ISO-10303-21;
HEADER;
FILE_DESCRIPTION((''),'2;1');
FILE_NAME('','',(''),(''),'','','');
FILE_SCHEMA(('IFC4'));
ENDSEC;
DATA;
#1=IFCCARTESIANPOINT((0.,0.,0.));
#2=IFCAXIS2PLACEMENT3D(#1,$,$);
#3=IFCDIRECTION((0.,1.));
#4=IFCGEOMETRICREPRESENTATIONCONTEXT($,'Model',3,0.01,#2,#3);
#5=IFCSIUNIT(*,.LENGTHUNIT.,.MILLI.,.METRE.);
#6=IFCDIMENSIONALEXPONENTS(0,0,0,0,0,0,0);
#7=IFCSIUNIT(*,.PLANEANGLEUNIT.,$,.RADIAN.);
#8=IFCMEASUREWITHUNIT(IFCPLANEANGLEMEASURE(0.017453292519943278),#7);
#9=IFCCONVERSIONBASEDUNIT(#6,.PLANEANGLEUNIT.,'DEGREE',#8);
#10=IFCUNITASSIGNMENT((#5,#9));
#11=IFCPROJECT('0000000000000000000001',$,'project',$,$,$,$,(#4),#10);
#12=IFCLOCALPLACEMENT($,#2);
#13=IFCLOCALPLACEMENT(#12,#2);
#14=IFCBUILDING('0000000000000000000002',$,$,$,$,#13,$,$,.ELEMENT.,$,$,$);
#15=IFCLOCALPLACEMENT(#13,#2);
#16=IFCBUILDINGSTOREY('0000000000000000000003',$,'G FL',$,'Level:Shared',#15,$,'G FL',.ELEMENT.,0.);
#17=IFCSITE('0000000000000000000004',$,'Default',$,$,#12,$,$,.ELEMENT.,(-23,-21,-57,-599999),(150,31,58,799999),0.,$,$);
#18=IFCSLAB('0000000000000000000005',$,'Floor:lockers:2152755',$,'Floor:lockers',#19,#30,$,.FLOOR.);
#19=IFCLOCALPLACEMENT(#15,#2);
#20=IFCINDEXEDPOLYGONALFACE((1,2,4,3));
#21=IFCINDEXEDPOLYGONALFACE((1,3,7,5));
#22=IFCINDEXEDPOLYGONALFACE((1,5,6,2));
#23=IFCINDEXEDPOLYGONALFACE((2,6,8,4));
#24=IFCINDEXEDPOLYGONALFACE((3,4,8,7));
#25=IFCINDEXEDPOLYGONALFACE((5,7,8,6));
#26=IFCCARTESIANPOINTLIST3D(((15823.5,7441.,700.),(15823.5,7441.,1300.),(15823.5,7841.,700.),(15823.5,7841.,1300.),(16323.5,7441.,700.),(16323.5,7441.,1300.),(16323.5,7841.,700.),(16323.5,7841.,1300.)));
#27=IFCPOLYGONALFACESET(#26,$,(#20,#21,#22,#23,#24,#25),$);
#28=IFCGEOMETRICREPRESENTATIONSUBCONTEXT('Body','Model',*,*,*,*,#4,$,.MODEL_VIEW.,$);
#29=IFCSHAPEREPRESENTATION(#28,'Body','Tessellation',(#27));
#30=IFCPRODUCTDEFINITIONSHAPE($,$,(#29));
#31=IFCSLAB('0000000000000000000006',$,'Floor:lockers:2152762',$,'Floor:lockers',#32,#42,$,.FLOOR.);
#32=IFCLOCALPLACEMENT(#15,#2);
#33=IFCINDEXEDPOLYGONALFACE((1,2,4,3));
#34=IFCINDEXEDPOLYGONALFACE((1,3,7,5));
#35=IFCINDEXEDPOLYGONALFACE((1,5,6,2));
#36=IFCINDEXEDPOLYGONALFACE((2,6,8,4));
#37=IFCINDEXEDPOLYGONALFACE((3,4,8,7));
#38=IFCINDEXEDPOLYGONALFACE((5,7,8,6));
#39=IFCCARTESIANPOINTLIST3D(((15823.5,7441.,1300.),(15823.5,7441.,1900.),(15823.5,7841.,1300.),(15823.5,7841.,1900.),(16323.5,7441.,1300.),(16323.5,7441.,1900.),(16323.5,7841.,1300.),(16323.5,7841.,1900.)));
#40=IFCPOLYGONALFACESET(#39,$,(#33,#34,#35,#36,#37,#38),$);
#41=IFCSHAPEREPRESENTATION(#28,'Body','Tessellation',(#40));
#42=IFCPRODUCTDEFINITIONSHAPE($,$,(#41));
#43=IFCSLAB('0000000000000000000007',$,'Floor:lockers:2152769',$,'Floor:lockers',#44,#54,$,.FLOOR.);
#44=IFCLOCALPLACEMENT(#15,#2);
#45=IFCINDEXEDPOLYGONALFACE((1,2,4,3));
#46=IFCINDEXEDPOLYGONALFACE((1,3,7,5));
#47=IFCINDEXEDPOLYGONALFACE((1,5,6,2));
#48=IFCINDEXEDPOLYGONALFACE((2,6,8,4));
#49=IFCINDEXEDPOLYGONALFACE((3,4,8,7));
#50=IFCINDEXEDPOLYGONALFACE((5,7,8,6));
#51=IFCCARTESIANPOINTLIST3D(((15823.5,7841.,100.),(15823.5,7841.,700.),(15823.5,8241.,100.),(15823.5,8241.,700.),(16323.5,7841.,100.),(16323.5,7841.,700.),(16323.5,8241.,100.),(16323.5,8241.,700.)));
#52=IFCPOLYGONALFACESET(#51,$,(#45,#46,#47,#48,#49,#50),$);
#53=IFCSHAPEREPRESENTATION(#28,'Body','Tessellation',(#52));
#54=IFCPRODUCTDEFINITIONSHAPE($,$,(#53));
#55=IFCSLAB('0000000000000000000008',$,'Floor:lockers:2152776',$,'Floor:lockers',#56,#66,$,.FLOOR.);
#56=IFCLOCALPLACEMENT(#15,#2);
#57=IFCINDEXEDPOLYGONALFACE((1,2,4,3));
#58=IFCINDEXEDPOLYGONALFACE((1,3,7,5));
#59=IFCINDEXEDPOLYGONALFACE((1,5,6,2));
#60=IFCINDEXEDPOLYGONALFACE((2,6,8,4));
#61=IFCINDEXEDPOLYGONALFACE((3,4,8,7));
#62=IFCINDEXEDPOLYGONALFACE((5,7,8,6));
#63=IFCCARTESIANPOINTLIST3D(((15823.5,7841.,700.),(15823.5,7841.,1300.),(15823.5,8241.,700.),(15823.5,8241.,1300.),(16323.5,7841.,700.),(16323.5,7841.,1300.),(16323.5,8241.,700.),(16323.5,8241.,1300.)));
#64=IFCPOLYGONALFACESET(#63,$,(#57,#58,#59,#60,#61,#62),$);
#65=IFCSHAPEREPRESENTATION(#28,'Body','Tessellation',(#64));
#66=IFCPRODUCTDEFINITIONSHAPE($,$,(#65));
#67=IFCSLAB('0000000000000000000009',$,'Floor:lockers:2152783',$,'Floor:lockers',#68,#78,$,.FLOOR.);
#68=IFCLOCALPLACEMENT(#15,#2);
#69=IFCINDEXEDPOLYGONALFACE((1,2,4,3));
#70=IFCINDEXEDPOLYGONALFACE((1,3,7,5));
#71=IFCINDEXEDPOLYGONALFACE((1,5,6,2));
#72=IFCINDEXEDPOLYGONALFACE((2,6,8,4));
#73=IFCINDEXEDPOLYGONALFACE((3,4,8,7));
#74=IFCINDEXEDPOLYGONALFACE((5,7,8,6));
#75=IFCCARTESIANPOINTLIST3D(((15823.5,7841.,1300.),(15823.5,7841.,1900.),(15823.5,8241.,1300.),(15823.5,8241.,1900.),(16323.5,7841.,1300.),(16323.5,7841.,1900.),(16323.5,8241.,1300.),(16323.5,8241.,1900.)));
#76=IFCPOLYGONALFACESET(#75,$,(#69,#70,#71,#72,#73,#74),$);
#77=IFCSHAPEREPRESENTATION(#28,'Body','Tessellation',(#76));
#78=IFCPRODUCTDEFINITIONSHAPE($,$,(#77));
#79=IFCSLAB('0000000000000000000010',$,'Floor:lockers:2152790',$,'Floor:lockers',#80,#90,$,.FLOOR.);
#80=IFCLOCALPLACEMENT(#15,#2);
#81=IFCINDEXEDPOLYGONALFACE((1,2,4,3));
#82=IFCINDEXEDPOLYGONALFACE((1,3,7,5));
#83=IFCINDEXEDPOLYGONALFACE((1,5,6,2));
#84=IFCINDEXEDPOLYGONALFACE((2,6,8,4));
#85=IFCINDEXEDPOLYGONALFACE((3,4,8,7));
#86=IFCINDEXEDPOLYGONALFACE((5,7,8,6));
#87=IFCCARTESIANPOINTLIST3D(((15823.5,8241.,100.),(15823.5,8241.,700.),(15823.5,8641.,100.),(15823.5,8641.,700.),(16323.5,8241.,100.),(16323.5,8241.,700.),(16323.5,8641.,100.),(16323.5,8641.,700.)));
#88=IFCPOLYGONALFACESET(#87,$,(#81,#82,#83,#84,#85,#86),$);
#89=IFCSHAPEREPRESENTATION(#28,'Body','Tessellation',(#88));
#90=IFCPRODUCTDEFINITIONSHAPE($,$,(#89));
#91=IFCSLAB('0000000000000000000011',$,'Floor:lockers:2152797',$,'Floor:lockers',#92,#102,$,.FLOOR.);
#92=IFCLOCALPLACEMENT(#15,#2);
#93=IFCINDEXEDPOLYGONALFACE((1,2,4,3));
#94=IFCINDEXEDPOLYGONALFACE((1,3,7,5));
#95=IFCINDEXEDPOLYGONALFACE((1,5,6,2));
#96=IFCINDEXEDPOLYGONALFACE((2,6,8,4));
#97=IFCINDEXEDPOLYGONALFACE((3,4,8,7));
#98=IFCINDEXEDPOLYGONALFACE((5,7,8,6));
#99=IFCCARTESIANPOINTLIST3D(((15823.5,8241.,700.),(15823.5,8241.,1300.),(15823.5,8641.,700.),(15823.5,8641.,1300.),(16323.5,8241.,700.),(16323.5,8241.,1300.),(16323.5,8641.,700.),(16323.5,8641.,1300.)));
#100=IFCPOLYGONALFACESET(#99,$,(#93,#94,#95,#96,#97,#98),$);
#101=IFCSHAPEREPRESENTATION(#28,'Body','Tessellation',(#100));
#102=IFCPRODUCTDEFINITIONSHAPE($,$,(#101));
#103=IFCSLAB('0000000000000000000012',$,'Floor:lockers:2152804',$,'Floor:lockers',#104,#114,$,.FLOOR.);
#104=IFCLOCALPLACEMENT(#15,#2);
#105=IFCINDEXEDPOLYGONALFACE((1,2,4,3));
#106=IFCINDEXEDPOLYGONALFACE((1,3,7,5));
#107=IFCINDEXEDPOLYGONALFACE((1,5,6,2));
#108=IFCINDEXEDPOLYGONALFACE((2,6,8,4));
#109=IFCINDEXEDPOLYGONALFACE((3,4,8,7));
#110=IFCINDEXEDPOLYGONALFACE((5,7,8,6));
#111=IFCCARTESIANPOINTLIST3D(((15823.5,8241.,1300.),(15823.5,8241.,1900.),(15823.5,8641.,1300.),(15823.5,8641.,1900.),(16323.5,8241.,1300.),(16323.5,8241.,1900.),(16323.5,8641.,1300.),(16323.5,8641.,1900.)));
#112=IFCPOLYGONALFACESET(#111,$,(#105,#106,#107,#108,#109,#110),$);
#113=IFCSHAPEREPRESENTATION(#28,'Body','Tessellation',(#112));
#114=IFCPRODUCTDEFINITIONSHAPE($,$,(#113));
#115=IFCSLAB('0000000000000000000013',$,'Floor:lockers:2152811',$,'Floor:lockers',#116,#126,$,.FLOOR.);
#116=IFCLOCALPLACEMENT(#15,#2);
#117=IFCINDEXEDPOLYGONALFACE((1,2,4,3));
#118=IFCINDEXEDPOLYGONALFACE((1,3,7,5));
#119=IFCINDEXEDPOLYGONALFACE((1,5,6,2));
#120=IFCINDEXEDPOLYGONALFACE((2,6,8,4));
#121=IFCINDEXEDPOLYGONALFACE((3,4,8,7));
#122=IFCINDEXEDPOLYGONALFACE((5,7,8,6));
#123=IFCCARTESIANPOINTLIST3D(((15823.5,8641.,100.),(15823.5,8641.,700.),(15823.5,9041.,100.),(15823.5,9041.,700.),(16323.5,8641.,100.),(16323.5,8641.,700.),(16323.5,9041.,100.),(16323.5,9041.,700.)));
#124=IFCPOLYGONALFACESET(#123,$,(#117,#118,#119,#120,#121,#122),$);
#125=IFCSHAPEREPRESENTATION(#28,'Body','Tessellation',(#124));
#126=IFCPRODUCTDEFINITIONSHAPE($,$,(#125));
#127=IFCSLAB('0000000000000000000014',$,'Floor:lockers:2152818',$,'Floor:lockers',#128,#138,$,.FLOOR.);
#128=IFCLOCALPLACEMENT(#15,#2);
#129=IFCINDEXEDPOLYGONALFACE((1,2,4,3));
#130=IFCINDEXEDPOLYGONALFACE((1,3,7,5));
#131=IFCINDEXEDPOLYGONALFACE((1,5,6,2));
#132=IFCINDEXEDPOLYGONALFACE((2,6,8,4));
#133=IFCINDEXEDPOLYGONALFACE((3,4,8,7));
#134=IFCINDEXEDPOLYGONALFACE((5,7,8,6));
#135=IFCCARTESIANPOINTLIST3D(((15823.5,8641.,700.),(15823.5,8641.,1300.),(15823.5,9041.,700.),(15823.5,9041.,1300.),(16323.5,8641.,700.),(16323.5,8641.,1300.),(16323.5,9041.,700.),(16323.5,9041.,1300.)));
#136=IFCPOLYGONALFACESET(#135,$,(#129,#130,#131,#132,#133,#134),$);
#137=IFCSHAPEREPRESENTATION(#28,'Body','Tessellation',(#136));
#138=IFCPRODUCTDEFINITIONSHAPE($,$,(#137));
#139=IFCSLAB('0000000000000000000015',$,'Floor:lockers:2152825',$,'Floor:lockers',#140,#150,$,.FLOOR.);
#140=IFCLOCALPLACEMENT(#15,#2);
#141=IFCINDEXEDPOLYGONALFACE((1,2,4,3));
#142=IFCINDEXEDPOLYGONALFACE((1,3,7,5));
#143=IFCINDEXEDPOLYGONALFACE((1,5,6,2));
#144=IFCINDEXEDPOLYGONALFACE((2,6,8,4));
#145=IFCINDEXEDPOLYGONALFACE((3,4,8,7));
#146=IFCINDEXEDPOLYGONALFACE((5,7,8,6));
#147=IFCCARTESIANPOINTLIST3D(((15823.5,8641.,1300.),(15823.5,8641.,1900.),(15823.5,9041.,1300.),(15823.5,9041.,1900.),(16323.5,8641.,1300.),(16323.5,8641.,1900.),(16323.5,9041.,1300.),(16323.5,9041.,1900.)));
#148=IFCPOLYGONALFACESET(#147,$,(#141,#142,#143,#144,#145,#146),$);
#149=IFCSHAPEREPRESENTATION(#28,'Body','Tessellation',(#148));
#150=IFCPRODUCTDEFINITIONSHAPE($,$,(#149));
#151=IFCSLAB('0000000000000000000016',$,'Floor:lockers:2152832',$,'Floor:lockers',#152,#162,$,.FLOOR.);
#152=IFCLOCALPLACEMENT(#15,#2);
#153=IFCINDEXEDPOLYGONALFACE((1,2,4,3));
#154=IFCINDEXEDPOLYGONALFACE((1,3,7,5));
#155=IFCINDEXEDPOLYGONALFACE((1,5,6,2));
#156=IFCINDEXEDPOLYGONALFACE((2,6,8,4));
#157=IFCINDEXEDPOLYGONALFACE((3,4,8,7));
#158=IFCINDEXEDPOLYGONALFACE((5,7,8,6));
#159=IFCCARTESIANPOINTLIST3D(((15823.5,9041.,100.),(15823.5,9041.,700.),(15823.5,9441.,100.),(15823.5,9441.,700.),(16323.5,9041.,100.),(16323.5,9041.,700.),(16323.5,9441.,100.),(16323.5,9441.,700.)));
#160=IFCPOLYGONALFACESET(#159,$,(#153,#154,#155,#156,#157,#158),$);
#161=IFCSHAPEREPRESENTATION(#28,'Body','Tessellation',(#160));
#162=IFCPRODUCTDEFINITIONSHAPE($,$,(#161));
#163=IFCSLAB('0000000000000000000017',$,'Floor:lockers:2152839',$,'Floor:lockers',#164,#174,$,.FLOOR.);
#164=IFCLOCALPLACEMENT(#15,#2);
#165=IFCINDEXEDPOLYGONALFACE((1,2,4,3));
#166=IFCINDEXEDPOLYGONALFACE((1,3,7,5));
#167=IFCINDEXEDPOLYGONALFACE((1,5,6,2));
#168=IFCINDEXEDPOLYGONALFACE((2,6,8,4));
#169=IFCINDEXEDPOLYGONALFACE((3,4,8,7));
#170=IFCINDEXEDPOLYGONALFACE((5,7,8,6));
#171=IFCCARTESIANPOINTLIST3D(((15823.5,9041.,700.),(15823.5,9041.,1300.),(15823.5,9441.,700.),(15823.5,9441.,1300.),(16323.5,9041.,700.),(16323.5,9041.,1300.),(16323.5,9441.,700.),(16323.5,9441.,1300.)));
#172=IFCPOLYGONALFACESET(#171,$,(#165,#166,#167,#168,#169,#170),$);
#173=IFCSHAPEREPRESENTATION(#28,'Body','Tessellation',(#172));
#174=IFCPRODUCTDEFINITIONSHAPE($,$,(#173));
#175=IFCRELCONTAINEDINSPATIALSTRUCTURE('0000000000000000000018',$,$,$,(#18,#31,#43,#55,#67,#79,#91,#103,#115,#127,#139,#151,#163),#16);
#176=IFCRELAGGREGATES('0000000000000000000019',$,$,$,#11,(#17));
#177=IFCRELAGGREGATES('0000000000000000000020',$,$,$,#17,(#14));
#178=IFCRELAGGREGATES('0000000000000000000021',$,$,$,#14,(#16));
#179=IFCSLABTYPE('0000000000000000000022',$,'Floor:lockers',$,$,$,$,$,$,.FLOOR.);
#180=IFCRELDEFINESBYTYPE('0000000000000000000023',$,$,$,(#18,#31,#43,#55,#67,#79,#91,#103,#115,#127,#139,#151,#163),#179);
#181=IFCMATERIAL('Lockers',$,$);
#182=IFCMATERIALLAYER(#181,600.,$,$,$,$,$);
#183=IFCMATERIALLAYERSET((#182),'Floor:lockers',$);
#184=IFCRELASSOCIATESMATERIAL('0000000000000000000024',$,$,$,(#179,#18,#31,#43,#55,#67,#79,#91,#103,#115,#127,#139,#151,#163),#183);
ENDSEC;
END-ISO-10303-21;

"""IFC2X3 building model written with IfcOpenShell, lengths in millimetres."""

from ifc_helpers import new_model, entity, si_unit, converted_unit, direction, frame, frame_2d, origin, place, context, subcontext, project, spatial, rectangle, extrude, material, layer, layer_set, layer_usage, type_object, element, save


model = new_model("IFC2X3")

# Units and contexts
model_context = context("Model", 3, precision=0.01, world=origin(), true_north=direction((0.0, 1.0)))
body_context = subcontext(model_context, "Body", "Model", "MODEL_VIEW")
ifc_project = project(units=[si_unit("LENGTHUNIT", "METRE", prefix="MILLI"), converted_unit("PLANEANGLEUNIT", "DEGREE", entity("IfcPlaneAngleMeasure", 0.017453292519943278), si_unit("PLANEANGLEUNIT", "RADIAN"), dimensions=[0, 0, 0, 0, 0, 0, 0])], contexts=[model_context])

# Site, building, storey
site_placement = place(None, origin())
site = spatial("IfcSite", under=ifc_project, at=site_placement, Name="Default", CompositionType="ELEMENT", RefLatitude=(-23, -21, -57, -599999), RefLongitude=(150, 31, 58, 799999), RefElevation=0.0)
building_placement = place(site_placement, origin())
building = spatial("IfcBuilding", under=site, at=building_placement, CompositionType="ELEMENT")
storey_placement = place(building_placement, origin())
storey = spatial("IfcBuildingStorey", under=building, at=storey_placement, Name="G FL", ObjectType="Level:Shared", LongName="G FL", CompositionType="ELEMENT", Elevation=0.0)

# Slabs
ifc_material = material(Name="Lockers")
ifc_layer = layer(ifc_material, 600.0)
ifc_layer_set = layer_set([ifc_layer], Name="Floor:lockers")
ifc_layer_usage_1 = layer_usage(ifc_layer_set, "AXIS3", "POSITIVE", 0.0)
slab_type = type_object("IfcSlabType", Name="Floor:lockers", PredefinedType="FLOOR", material=ifc_layer_set)
slab_1_placement = place(storey_placement, origin())
element("IfcSlab", 1, at=slab_1_placement, inside=storey, type_object=slab_type, material=ifc_layer_usage_1, Name="Floor:lockers:2152755", ObjectType="Floor:lockers", PredefinedType="FLOOR", context=body_context, shape_type="SweptSolid", body=[
    extrude(rectangle(XDim=400.0, YDim=500.0, at=frame_2d((0.0, 0.0), x_axis=(1.0, 0.0))), frame((16073.5, 7641.0, 1300.0), z_axis=(0.0, 0.0, -1.0), x_axis=(0.0, 1.0, 0.0)), (0.0, 0.0, 1.0), 600.0),
])
ifc_layer_usage_2 = layer_usage(ifc_layer_set, "AXIS3", "POSITIVE", 0.0)
slab_2_placement = place(storey_placement, origin())
element("IfcSlab", 2, at=slab_2_placement, inside=storey, type_object=slab_type, material=ifc_layer_usage_2, Name="Floor:lockers:2152762", ObjectType="Floor:lockers", PredefinedType="FLOOR", context=body_context, shape_type="SweptSolid", body=[
    extrude(rectangle(XDim=400.0, YDim=500.0, at=frame_2d((0.0, 0.0), x_axis=(1.0, 0.0))), frame((16073.5, 7641.0, 1900.0), z_axis=(0.0, 0.0, -1.0), x_axis=(0.0, 1.0, 0.0)), (0.0, 0.0, 1.0), 600.0),
])
ifc_layer_usage_3 = layer_usage(ifc_layer_set, "AXIS3", "POSITIVE", 0.0)
slab_3_placement = place(storey_placement, origin())
element("IfcSlab", 3, at=slab_3_placement, inside=storey, type_object=slab_type, material=ifc_layer_usage_3, Name="Floor:lockers:2152769", ObjectType="Floor:lockers", PredefinedType="FLOOR", context=body_context, shape_type="SweptSolid", body=[
    extrude(rectangle(XDim=400.0, YDim=500.0, at=frame_2d((0.0, 0.0), x_axis=(1.0, 0.0))), frame((16073.5, 8041.0, 700.0), z_axis=(0.0, 0.0, -1.0), x_axis=(0.0, 1.0, 0.0)), (0.0, 0.0, 1.0), 600.0),
])
ifc_layer_usage_4 = layer_usage(ifc_layer_set, "AXIS3", "POSITIVE", 0.0)
slab_4_placement = place(storey_placement, origin())
element("IfcSlab", 4, at=slab_4_placement, inside=storey, type_object=slab_type, material=ifc_layer_usage_4, Name="Floor:lockers:2152776", ObjectType="Floor:lockers", PredefinedType="FLOOR", context=body_context, shape_type="SweptSolid", body=[
    extrude(rectangle(XDim=400.0, YDim=500.0, at=frame_2d((0.0, 0.0), x_axis=(1.0, 0.0))), frame((16073.5, 8041.0, 1300.0), z_axis=(0.0, 0.0, -1.0), x_axis=(0.0, 1.0, 0.0)), (0.0, 0.0, 1.0), 600.0),
])
ifc_layer_usage_5 = layer_usage(ifc_layer_set, "AXIS3", "POSITIVE", 0.0)
slab_5_placement = place(storey_placement, origin())
element("IfcSlab", 5, at=slab_5_placement, inside=storey, type_object=slab_type, material=ifc_layer_usage_5, Name="Floor:lockers:2152783", ObjectType="Floor:lockers", PredefinedType="FLOOR", context=body_context, shape_type="SweptSolid", body=[
    extrude(rectangle(XDim=400.0, YDim=500.0, at=frame_2d((0.0, 0.0), x_axis=(1.0, 0.0))), frame((16073.5, 8041.0, 1900.0), z_axis=(0.0, 0.0, -1.0), x_axis=(0.0, 1.0, 0.0)), (0.0, 0.0, 1.0), 600.0),
])
ifc_layer_usage_6 = layer_usage(ifc_layer_set, "AXIS3", "POSITIVE", 0.0)
slab_6_placement = place(storey_placement, origin())
element("IfcSlab", 6, at=slab_6_placement, inside=storey, type_object=slab_type, material=ifc_layer_usage_6, Name="Floor:lockers:2152790", ObjectType="Floor:lockers", PredefinedType="FLOOR", context=body_context, shape_type="SweptSolid", body=[
    extrude(rectangle(XDim=400.0, YDim=500.0, at=frame_2d((0.0, 0.0), x_axis=(1.0, 0.0))), frame((16073.5, 8441.0, 700.0), z_axis=(0.0, 0.0, -1.0), x_axis=(0.0, 1.0, 0.0)), (0.0, 0.0, 1.0), 600.0),
])
ifc_layer_usage_7 = layer_usage(ifc_layer_set, "AXIS3", "POSITIVE", 0.0)
slab_7_placement = place(storey_placement, origin())
element("IfcSlab", 7, at=slab_7_placement, inside=storey, type_object=slab_type, material=ifc_layer_usage_7, Name="Floor:lockers:2152797", ObjectType="Floor:lockers", PredefinedType="FLOOR", context=body_context, shape_type="SweptSolid", body=[
    extrude(rectangle(XDim=400.0, YDim=500.0, at=frame_2d((0.0, 0.0), x_axis=(1.0, 0.0))), frame((16073.5, 8441.0, 1300.0), z_axis=(0.0, 0.0, -1.0), x_axis=(0.0, 1.0, 0.0)), (0.0, 0.0, 1.0), 600.0),
])
ifc_layer_usage_8 = layer_usage(ifc_layer_set, "AXIS3", "POSITIVE", 0.0)
slab_8_placement = place(storey_placement, origin())
element("IfcSlab", 8, at=slab_8_placement, inside=storey, type_object=slab_type, material=ifc_layer_usage_8, Name="Floor:lockers:2152804", ObjectType="Floor:lockers", PredefinedType="FLOOR", context=body_context, shape_type="SweptSolid", body=[
    extrude(rectangle(XDim=400.0, YDim=500.0, at=frame_2d((0.0, 0.0), x_axis=(1.0, 0.0))), frame((16073.5, 8441.0, 1900.0), z_axis=(0.0, 0.0, -1.0), x_axis=(0.0, 1.0, 0.0)), (0.0, 0.0, 1.0), 600.0),
])
ifc_layer_usage_9 = layer_usage(ifc_layer_set, "AXIS3", "POSITIVE", 0.0)
slab_9_placement = place(storey_placement, origin())
element("IfcSlab", 9, at=slab_9_placement, inside=storey, type_object=slab_type, material=ifc_layer_usage_9, Name="Floor:lockers:2152811", ObjectType="Floor:lockers", PredefinedType="FLOOR", context=body_context, shape_type="SweptSolid", body=[
    extrude(rectangle(XDim=400.0, YDim=500.0, at=frame_2d((0.0, 0.0), x_axis=(1.0, 0.0))), frame((16073.5, 8841.0, 700.0), z_axis=(0.0, 0.0, -1.0), x_axis=(0.0, 1.0, 0.0)), (0.0, 0.0, 1.0), 600.0),
])
ifc_layer_usage_10 = layer_usage(ifc_layer_set, "AXIS3", "POSITIVE", 0.0)
slab_10_placement = place(storey_placement, origin())
element("IfcSlab", 10, at=slab_10_placement, inside=storey, type_object=slab_type, material=ifc_layer_usage_10, Name="Floor:lockers:2152818", ObjectType="Floor:lockers", PredefinedType="FLOOR", context=body_context, shape_type="SweptSolid", body=[
    extrude(rectangle(XDim=400.0, YDim=500.0, at=frame_2d((0.0, 0.0), x_axis=(1.0, 0.0))), frame((16073.5, 8841.0, 1300.0), z_axis=(0.0, 0.0, -1.0), x_axis=(0.0, 1.0, 0.0)), (0.0, 0.0, 1.0), 600.0),
])
ifc_layer_usage_11 = layer_usage(ifc_layer_set, "AXIS3", "POSITIVE", 0.0)
slab_11_placement = place(storey_placement, origin())
element("IfcSlab", 11, at=slab_11_placement, inside=storey, type_object=slab_type, material=ifc_layer_usage_11, Name="Floor:lockers:2152825", ObjectType="Floor:lockers", PredefinedType="FLOOR", context=body_context, shape_type="SweptSolid", body=[
    extrude(rectangle(XDim=400.0, YDim=500.0, at=frame_2d((0.0, 0.0), x_axis=(1.0, 0.0))), frame((16073.5, 8841.0, 1900.0), z_axis=(0.0, 0.0, -1.0), x_axis=(0.0, 1.0, 0.0)), (0.0, 0.0, 1.0), 600.0),
])
ifc_layer_usage_12 = layer_usage(ifc_layer_set, "AXIS3", "POSITIVE", 0.0)
slab_12_placement = place(storey_placement, origin())
element("IfcSlab", 12, at=slab_12_placement, inside=storey, type_object=slab_type, material=ifc_layer_usage_12, Name="Floor:lockers:2152832", ObjectType="Floor:lockers", PredefinedType="FLOOR", context=body_context, shape_type="SweptSolid", body=[
    extrude(rectangle(XDim=400.0, YDim=500.0, at=frame_2d((0.0, 0.0), x_axis=(1.0, 0.0))), frame((16073.5, 9241.0, 700.0), z_axis=(0.0, 0.0, -1.0), x_axis=(0.0, 1.0, 0.0)), (0.0, 0.0, 1.0), 600.0),
])
ifc_layer_usage_13 = layer_usage(ifc_layer_set, "AXIS3", "POSITIVE", 0.0)
slab_13_placement = place(storey_placement, origin())
element("IfcSlab", 13, at=slab_13_placement, inside=storey, type_object=slab_type, material=ifc_layer_usage_13, Name="Floor:lockers:2152839", ObjectType="Floor:lockers", PredefinedType="FLOOR", context=body_context, shape_type="SweptSolid", body=[
    extrude(rectangle(XDim=400.0, YDim=500.0, at=frame_2d((0.0, 0.0), x_axis=(1.0, 0.0))), frame((16073.5, 9241.0, 1300.0), z_axis=(0.0, 0.0, -1.0), x_axis=(0.0, 1.0, 0.0)), (0.0, 0.0, 1.0), 600.0),
])

save(model, "model.ifc")
